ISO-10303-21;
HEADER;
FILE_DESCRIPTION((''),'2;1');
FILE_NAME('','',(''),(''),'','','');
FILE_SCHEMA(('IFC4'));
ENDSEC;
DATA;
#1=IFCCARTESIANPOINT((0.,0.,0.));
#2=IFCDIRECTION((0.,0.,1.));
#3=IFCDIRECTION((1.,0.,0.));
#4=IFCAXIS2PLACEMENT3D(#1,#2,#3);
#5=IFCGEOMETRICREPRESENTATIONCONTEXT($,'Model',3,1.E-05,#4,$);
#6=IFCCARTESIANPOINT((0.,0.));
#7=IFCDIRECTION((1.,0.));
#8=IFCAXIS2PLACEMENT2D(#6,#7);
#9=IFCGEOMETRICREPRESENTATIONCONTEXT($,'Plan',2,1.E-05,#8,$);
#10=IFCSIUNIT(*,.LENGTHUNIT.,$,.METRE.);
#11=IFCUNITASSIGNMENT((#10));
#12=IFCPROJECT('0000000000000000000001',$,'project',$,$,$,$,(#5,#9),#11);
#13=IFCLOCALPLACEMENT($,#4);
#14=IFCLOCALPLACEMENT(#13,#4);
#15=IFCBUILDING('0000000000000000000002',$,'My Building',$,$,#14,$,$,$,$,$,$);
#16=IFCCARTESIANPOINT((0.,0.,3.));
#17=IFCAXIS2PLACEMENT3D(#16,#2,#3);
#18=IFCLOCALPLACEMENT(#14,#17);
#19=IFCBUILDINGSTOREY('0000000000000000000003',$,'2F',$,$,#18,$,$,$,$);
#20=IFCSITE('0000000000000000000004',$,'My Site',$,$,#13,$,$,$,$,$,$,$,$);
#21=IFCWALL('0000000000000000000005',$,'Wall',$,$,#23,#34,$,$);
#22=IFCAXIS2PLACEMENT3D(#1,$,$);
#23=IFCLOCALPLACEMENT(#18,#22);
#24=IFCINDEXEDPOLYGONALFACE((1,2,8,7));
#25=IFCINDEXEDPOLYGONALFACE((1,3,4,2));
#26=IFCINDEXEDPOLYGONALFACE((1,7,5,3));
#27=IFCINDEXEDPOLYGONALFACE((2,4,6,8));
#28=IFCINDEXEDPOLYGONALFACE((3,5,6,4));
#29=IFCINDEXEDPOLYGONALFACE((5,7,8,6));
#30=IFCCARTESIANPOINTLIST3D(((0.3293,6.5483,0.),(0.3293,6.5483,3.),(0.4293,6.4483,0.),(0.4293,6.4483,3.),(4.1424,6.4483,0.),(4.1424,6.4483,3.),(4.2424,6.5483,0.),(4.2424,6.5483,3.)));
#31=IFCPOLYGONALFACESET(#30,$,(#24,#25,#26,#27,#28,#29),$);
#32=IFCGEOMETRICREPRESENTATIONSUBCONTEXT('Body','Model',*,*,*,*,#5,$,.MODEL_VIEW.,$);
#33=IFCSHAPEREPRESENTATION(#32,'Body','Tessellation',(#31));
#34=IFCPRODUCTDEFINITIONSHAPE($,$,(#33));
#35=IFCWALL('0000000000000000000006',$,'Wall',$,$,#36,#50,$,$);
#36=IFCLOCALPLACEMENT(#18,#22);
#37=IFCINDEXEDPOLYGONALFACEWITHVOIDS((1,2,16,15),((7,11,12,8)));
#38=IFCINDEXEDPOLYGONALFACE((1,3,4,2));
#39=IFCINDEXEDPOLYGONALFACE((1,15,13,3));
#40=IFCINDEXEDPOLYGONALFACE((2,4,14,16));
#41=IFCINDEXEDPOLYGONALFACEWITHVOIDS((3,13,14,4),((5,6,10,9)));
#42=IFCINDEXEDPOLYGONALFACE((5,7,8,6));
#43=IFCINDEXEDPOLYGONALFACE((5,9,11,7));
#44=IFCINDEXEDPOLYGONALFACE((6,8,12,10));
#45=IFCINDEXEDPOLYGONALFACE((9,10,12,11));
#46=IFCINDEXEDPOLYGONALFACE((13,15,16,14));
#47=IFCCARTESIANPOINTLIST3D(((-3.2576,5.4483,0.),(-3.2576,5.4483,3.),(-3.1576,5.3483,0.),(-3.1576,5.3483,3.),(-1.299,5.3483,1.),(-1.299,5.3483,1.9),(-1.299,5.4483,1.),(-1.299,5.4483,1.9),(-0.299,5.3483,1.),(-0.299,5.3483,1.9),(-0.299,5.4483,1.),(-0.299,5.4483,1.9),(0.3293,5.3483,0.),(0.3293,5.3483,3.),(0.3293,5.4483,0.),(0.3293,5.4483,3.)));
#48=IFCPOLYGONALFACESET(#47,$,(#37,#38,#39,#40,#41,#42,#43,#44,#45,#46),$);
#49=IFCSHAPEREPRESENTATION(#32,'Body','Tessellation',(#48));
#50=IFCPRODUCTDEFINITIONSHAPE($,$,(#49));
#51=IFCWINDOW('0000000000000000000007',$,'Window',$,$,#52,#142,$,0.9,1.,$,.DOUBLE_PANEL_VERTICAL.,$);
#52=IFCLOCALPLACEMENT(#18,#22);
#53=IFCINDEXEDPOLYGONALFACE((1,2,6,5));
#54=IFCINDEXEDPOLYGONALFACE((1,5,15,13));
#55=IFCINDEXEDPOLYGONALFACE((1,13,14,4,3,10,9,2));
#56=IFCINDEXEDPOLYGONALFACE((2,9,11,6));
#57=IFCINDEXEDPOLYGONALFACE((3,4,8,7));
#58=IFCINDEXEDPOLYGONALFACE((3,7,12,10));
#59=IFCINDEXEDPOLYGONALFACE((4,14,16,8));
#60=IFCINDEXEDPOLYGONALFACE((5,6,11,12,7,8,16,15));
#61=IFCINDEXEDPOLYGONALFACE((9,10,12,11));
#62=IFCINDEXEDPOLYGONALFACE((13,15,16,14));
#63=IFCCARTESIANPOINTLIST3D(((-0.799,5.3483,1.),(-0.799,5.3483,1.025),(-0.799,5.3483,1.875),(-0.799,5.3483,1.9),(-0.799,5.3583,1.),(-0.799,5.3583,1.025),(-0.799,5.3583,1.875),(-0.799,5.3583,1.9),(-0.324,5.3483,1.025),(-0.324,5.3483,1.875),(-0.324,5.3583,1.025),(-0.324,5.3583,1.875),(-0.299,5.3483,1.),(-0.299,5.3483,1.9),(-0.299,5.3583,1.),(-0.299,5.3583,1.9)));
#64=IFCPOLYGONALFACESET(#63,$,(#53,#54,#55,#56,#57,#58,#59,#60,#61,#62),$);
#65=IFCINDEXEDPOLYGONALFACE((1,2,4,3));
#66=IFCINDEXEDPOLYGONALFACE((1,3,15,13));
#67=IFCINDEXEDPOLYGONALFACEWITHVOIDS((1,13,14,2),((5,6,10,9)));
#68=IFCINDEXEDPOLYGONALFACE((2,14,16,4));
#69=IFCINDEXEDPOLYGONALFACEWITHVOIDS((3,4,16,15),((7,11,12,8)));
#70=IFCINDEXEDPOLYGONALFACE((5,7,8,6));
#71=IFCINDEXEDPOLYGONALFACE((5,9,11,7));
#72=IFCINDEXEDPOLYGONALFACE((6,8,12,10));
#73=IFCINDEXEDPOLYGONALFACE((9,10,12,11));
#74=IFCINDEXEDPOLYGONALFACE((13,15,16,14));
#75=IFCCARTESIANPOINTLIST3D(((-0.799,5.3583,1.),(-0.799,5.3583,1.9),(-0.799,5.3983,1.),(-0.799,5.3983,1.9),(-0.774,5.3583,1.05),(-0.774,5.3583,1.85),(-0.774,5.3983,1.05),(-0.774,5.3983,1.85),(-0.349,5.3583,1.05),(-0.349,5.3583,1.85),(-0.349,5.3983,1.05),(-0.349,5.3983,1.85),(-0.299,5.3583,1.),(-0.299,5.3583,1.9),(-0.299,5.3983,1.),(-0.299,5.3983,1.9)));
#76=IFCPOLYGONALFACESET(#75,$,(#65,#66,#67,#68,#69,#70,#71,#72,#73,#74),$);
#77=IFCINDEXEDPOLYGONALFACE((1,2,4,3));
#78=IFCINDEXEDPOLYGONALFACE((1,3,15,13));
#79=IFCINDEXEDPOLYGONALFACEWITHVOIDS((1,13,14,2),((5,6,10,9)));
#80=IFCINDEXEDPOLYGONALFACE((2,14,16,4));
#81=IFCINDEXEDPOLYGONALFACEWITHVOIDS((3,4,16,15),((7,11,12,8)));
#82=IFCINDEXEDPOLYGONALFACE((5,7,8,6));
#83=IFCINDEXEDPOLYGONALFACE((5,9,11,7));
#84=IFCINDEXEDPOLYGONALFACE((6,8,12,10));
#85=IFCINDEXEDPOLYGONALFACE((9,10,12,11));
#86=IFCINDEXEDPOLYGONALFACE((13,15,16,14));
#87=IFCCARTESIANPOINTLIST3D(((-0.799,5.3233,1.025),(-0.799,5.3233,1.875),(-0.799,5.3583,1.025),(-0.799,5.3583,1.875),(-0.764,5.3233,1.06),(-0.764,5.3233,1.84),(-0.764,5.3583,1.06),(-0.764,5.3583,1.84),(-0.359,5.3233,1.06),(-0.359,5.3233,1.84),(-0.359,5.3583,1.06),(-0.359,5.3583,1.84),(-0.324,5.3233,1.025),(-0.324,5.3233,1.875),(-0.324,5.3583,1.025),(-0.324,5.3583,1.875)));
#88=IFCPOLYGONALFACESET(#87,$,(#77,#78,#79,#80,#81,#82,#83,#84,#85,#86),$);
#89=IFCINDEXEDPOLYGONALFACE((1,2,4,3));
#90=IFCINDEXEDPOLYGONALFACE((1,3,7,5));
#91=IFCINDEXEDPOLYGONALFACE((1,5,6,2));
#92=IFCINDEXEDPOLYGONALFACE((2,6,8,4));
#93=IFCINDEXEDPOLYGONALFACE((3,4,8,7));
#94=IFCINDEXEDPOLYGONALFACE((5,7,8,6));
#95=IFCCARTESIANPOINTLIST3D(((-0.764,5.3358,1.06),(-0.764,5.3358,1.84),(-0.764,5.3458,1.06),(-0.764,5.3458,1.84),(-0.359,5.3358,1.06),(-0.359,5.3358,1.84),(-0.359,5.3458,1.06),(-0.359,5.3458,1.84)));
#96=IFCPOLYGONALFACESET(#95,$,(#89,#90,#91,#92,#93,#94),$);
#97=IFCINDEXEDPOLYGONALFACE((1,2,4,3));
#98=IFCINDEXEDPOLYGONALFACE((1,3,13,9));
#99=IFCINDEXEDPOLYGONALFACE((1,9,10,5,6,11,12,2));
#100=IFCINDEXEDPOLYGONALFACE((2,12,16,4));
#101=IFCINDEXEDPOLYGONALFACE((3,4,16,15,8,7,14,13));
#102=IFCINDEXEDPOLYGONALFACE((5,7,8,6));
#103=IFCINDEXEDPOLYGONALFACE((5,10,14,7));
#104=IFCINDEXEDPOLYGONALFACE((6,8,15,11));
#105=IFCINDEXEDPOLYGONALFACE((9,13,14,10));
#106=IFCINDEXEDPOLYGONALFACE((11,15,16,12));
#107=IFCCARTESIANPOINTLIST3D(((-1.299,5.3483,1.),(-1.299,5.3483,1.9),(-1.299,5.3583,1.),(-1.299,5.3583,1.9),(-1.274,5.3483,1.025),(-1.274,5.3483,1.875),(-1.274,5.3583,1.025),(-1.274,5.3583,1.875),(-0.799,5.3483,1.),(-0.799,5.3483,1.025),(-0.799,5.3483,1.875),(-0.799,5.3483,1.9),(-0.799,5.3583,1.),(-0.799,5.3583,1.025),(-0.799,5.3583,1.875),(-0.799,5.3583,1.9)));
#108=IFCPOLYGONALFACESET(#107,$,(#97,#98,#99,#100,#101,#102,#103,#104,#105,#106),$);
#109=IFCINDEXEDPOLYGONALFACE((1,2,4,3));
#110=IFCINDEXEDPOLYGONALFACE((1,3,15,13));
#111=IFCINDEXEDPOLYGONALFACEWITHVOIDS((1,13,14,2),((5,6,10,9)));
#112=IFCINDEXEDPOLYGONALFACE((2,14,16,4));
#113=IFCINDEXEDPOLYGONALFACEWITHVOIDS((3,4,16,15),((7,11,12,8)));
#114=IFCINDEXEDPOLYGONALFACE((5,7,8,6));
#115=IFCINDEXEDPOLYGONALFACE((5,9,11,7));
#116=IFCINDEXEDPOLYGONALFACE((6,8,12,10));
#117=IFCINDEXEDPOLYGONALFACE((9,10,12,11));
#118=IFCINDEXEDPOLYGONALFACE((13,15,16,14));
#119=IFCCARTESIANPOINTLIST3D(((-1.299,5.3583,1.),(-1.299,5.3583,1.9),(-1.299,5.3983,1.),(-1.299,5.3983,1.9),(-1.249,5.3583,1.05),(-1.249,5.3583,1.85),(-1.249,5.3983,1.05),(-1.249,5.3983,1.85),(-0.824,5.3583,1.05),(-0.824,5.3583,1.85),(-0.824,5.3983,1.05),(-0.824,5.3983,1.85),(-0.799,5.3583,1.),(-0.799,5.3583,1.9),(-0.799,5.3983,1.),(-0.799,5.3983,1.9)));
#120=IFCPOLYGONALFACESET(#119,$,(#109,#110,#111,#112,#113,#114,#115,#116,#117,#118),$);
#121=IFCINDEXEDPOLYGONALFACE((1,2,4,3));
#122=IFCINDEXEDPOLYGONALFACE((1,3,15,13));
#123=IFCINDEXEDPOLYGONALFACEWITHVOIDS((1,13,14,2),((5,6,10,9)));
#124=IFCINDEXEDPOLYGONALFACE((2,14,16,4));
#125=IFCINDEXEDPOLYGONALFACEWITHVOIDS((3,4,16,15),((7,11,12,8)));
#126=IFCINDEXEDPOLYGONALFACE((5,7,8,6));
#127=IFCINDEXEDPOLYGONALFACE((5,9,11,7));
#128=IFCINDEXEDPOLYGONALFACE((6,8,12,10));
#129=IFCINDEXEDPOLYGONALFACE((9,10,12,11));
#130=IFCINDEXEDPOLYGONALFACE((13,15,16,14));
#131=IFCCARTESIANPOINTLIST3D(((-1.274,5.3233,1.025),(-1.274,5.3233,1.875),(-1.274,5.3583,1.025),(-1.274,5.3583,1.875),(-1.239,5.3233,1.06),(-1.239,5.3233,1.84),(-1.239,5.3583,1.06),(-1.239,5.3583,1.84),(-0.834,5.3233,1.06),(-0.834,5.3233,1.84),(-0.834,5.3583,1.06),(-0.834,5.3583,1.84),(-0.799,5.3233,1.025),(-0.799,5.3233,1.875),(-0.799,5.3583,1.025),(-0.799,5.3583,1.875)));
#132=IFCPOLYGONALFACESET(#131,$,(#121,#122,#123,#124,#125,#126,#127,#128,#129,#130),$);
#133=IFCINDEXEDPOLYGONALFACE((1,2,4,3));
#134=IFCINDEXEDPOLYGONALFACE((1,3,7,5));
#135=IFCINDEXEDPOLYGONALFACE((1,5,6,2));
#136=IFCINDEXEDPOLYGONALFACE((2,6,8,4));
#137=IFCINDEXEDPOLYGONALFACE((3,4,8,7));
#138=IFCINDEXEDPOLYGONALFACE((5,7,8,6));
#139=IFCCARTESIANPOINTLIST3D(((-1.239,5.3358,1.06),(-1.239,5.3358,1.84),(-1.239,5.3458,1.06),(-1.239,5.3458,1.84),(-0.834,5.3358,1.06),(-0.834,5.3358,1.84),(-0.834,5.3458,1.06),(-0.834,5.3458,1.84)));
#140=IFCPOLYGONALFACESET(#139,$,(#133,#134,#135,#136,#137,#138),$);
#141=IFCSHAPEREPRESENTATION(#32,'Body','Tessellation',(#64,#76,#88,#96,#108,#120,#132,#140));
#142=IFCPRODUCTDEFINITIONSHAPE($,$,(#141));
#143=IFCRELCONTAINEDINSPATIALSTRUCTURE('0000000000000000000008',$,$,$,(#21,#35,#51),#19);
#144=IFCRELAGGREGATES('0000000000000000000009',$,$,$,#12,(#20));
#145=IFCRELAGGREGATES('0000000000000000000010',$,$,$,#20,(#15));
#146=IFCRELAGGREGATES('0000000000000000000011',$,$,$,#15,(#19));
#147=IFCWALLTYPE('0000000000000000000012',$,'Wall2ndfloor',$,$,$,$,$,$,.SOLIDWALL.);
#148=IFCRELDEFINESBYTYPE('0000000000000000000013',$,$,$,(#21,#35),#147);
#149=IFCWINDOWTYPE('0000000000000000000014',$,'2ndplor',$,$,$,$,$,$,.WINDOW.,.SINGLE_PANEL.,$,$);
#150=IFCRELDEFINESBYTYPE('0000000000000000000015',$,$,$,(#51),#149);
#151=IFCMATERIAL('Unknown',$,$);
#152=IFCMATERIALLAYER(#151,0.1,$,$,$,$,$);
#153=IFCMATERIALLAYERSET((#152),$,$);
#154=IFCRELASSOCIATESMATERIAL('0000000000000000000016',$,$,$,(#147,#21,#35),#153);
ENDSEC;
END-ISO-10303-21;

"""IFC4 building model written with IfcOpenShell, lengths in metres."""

from ifc_helpers import new_model, entity, si_unit, frame, origin_with_axes, origin_2d_with_axis, place, context, subcontext, project, spatial, line, indexed_curve, outline, extrude, shape, source, transform, mapped, material, layer, layer_set, layer_usage, type_object, type_shapes, element, fill, save


model = new_model("IFC4")

# Units and contexts
model_context = context("Model", 3, precision=1e-05, world=origin_with_axes())
plan_context = context("Plan", 2, precision=1e-05, world=origin_2d_with_axis())
body_context_1 = subcontext(model_context, "Body", "Model", "MODEL_VIEW")
body_context_2 = subcontext(plan_context, "Body", "Plan", "PLAN_VIEW")
ifc_project = project(units=[si_unit("LENGTHUNIT", "METRE")], contexts=[model_context, plan_context])

# Site, building, storey
site_placement = place(None, origin_with_axes())
site = spatial("IfcSite", under=ifc_project, at=site_placement, Name="My Site")
building_placement = place(site_placement, origin_with_axes())
building = spatial("IfcBuilding", under=site, at=building_placement, Name="My Building")
storey_placement = place(building_placement, frame((0.0, 0.0, 3.0), z_axis=(0.0, 0.0, 1.0), x_axis=(1.0, 0.0, 0.0)))
storey = spatial("IfcBuildingStorey", under=building, at=storey_placement, Name="2F")

# Shared definitions
ifc_material = material(Name="Unknown")

# Wall
ifc_layer_1 = layer(ifc_material, 0.1)
ifc_layer_set_1 = layer_set([ifc_layer_1])
ifc_layer_usage_1 = layer_usage(ifc_layer_set_1, "AXIS2", "POSITIVE", 0.0)
wall_type = type_object("IfcWallType", Name="Wall2ndfloor", PredefinedType="SOLIDWALL", material=ifc_layer_set_1)
wall_1_placement = place(storey_placement, frame((4.2424, 6.5483, 0.0), z_axis=(0.0, 0.0, 1.0), x_axis=(-1.0, 0.0, 0.0)))
element("IfcWall", 1, at=wall_1_placement, inside=storey, type_object=wall_type, material=ifc_layer_usage_1, Name="Wall", context=body_context_1, shape_type="SweptSolid", body=[
    extrude(outline(indexed_curve([(0.0, 0.0), (0.1, 0.1), (3.8131, 0.1), (3.9131, 0.0)], segments=[line(1, 2, 3, 4, 1)])), origin_with_axes(), (0.0, 0.0, 1.0), 3.0),
])

# Wall, opening, window
ifc_layer_usage_2 = layer_usage(ifc_layer_set_1, "AXIS2", "POSITIVE", 0.0)
wall_2_placement = place(storey_placement, frame((0.4293, 5.4483, 0.0), z_axis=(0.0, 0.0, 1.0), x_axis=(-1.0, 0.0, 0.0)))
wall_2 = element("IfcWall", 2, at=wall_2_placement, inside=storey, type_object=wall_type, material=ifc_layer_usage_2, Name="Wall", context=body_context_1, shape_type="SweptSolid", body=[
    extrude(outline(indexed_curve([(0.1, 0.0), (0.1, 0.1), (3.5869, 0.1), (3.6869, 0.0)], segments=[line(1, 2, 3, 4, 1)])), origin_with_axes(), (0.0, 0.0, 1.0), 3.0),
])
shared_shape_1 = source(origin_with_axes(), body_context_1, "Body", "SweptSolid", [
    extrude(outline(indexed_curve([(0.0, 0.0), (1.0, 0.0), (1.0, 0.9), (0.0, 0.9)], segments=[line(1, 2, 3, 4, 1)])), frame((0.0, -0.6, 0.0), z_axis=(0.0, -1.0, 0.0), x_axis=(1.0, 0.0, 0.0)), (0.0, 0.0, -1.0), 1.2),
])
opening_1_placement = place(wall_2_placement, frame((0.7283, 0.0, 1.0), z_axis=(0.0, 0.0, 1.0), x_axis=(1.0, 0.0, 0.0)))
opening_1 = element("IfcOpeningElement", 3, at=opening_1_placement, cuts=wall_2, PredefinedType="OPENING", context=body_context_1, shape_type="MappedRepresentation", body=[
    mapped(shared_shape_1, transform((0.0, 0.0, 0.0), x_axis=(1.0, 0.0, 0.0), y_axis=(0.0, 1.0, 0.0), z_axis=(0.0, 0.0, 1.0), scale=1.0)),
])
window_type_1 = type_object("IfcWindowType", Name="2ndplor", PartitioningType="SINGLE_PANEL", PredefinedType="WINDOW")
shared_shape_2 = source(origin_with_axes(), body_context_1, "Body", "SweptSolid", [
    extrude(outline(indexed_curve([(0.5, 0.0), (0.0, 0.0), (0.0, 0.9), (0.5, 0.9), (0.5, 0.875), (0.025, 0.875), (0.025, 0.025), (0.5, 0.025)], segments=[line(1, 2, 3, 4, 5, 6, 7, 8, 1)])), frame((0.0, 0.09, 0.0), z_axis=(0.0, -1.0, 0.0), x_axis=(1.0, 0.0, 0.0)), (0.0, 0.0, -1.0), 0.01),
    extrude(outline(indexed_curve([(0.0, 0.0), (0.5, 0.0), (0.5, 0.9), (0.0, 0.9)], segments=[line(1, 2, 3, 4, 1)]), holes=[indexed_curve([(0.05, 0.05), (0.475, 0.05), (0.475, 0.85), (0.05, 0.85)], segments=[line(1, 2, 3, 4, 1)])]), frame((0.0, 0.05, 0.0), z_axis=(0.0, -1.0, 0.0), x_axis=(1.0, 0.0, 0.0)), (0.0, 0.0, -1.0), 0.04),
    extrude(outline(indexed_curve([(0.0, 0.0), (0.475, 0.0), (0.475, 0.85), (0.0, 0.85)], segments=[line(1, 2, 3, 4, 1)]), holes=[indexed_curve([(0.035, 0.035), (0.44, 0.035), (0.44, 0.815), (0.035, 0.815)], segments=[line(1, 2, 3, 4, 1)])]), frame((0.025, 0.09, 0.025), z_axis=(0.0, -1.0, 0.0), x_axis=(1.0, 0.0, 0.0)), (0.0, 0.0, -1.0), 0.035),
    extrude(outline(indexed_curve([(0.035, 0.035), (0.44, 0.035), (0.44, 0.815), (0.035, 0.815)], segments=[line(1, 2, 3, 4, 1)])), frame((0.025, 0.1025, 0.025), z_axis=(0.0, -1.0, 0.0), x_axis=(1.0, 0.0, 0.0)), (0.0, 0.0, -1.0), 0.01),
    extrude(outline(indexed_curve([(0.0, 0.9), (0.5, 0.9), (0.5, 0.0), (0.0, 0.0), (0.0, 0.025), (0.475, 0.025), (0.475, 0.875), (0.0, 0.875)], segments=[line(1, 2, 3, 4, 5, 6, 7, 8, 1)])), frame((0.5, 0.09, 0.0), z_axis=(0.0, -1.0, 0.0), x_axis=(1.0, 0.0, 0.0)), (0.0, 0.0, -1.0), 0.01),
    extrude(outline(indexed_curve([(0.0, 0.0), (0.5, 0.0), (0.5, 0.9), (0.0, 0.9)], segments=[line(1, 2, 3, 4, 1)]), holes=[indexed_curve([(0.025, 0.05), (0.45, 0.05), (0.45, 0.85), (0.025, 0.85)], segments=[line(1, 2, 3, 4, 1)])]), frame((0.5, 0.05, 0.0), z_axis=(0.0, -1.0, 0.0), x_axis=(1.0, 0.0, 0.0)), (0.0, 0.0, -1.0), 0.04),
    extrude(outline(indexed_curve([(0.0, 0.0), (0.475, 0.0), (0.475, 0.85), (0.0, 0.85)], segments=[line(1, 2, 3, 4, 1)]), holes=[indexed_curve([(0.035, 0.035), (0.44, 0.035), (0.44, 0.815), (0.035, 0.815)], segments=[line(1, 2, 3, 4, 1)])]), frame((0.5, 0.09, 0.025), z_axis=(0.0, -1.0, 0.0), x_axis=(1.0, 0.0, 0.0)), (0.0, 0.0, -1.0), 0.035),
    extrude(outline(indexed_curve([(0.035, 0.035), (0.44, 0.035), (0.44, 0.815), (0.035, 0.815)], segments=[line(1, 2, 3, 4, 1)])), frame((0.5, 0.1025, 0.025), z_axis=(0.0, -1.0, 0.0), x_axis=(1.0, 0.0, 0.0)), (0.0, 0.0, -1.0), 0.01),
])
shared_shape_3 = source(origin_with_axes(), body_context_2, "Body", "Curve2D", [
    entity("IfcIndexedPolyCurve", entity("IfcCartesianPointList2D", [[0.05, 0.05], [0.475, 0.05]])),
    entity("IfcIndexedPolyCurve", entity("IfcCartesianPointList2D", [[0.0, 0.1], [0.025, 0.1], [0.025, 0.09], [0.05, 0.09], [0.05, 0.05], [0.0, 0.05]]), [entity("IfcLineIndex", [1, 2, 3, 4, 5, 6, 1])]),
    entity("IfcIndexedPolyCurve", entity("IfcCartesianPointList2D", [[0.5, 0.1], [0.5, 0.1], [0.5, 0.09], [0.475, 0.09], [0.475, 0.05], [0.5, 0.05]])),
    entity("IfcIndexedPolyCurve", entity("IfcCartesianPointList2D", [[0.025, 0.09], [0.06, 0.09], [0.06, 0.125], [0.025, 0.125]]), [entity("IfcLineIndex", [1, 2, 3, 4, 1])]),
    entity("IfcIndexedPolyCurve", entity("IfcCartesianPointList2D", [[0.5, 0.09], [0.465, 0.09], [0.465, 0.125], [0.5, 0.125]]), [entity("IfcLineIndex", [1, 2, 3, 4, 1])]),
    entity("IfcIndexedPolyCurve", entity("IfcCartesianPointList2D", [[0.06, 0.09], [0.465, 0.09]])),
    entity("IfcIndexedPolyCurve", entity("IfcCartesianPointList2D", [[0.06, 0.125], [0.465, 0.125]])),
    entity("IfcIndexedPolyCurve", entity("IfcCartesianPointList2D", [[0.06, 0.1075], [0.465, 0.1075]])),
    entity("IfcIndexedPolyCurve", entity("IfcCartesianPointList2D", [[0.525, 0.05], [0.95, 0.05]])),
    entity("IfcIndexedPolyCurve", entity("IfcCartesianPointList2D", [[0.5, 0.1], [0.5, 0.1], [0.5, 0.09], [0.525, 0.09], [0.525, 0.05], [0.5, 0.05]])),
    entity("IfcIndexedPolyCurve", entity("IfcCartesianPointList2D", [[1.0, 0.1], [0.975, 0.1], [0.975, 0.09], [0.95, 0.09], [0.95, 0.05], [1.0, 0.05]]), [entity("IfcLineIndex", [1, 2, 3, 4, 5, 6, 1])]),
    entity("IfcIndexedPolyCurve", entity("IfcCartesianPointList2D", [[0.5, 0.09], [0.535, 0.09], [0.535, 0.125], [0.5, 0.125]]), [entity("IfcLineIndex", [1, 2, 3, 4, 1])]),
    entity("IfcIndexedPolyCurve", entity("IfcCartesianPointList2D", [[0.975, 0.09], [0.94, 0.09], [0.94, 0.125], [0.975, 0.125]]), [entity("IfcLineIndex", [1, 2, 3, 4, 1])]),
    entity("IfcIndexedPolyCurve", entity("IfcCartesianPointList2D", [[0.535, 0.09], [0.94, 0.09]])),
    entity("IfcIndexedPolyCurve", entity("IfcCartesianPointList2D", [[0.535, 0.125], [0.94, 0.125]])),
    entity("IfcIndexedPolyCurve", entity("IfcCartesianPointList2D", [[0.535, 0.1075], [0.94, 0.1075]])),
])
type_shapes(window_type_1, [shared_shape_2, shared_shape_3])
window_1_placement = place(opening_1_placement, origin_with_axes())
window_1 = element("IfcWindow", 4, at=window_1_placement, inside=storey, type_object=window_type_1, Name="Window", OverallHeight=0.9, OverallWidth=1.0, PartitioningType="DOUBLE_PANEL_VERTICAL", shapes=[
    shape(body_context_1, "Body", "MappedRepresentation", [mapped(shared_shape_2, transform((0.0, 0.0, 0.0), x_axis=(1.0, 0.0, 0.0), y_axis=(0.0, 1.0, 0.0), z_axis=(0.0, 0.0, 1.0), scale=1.0))]),
    shape(body_context_2, "Body", "MappedRepresentation", [mapped(shared_shape_3, transform((0.0, 0.0, 0.0), x_axis=(1.0, 0.0, 0.0), y_axis=(0.0, 1.0, 0.0), z_axis=(0.0, 0.0, 1.0), scale=1.0))]),
])
fill(opening_1, window_1)

save(model, "model.ifc")
